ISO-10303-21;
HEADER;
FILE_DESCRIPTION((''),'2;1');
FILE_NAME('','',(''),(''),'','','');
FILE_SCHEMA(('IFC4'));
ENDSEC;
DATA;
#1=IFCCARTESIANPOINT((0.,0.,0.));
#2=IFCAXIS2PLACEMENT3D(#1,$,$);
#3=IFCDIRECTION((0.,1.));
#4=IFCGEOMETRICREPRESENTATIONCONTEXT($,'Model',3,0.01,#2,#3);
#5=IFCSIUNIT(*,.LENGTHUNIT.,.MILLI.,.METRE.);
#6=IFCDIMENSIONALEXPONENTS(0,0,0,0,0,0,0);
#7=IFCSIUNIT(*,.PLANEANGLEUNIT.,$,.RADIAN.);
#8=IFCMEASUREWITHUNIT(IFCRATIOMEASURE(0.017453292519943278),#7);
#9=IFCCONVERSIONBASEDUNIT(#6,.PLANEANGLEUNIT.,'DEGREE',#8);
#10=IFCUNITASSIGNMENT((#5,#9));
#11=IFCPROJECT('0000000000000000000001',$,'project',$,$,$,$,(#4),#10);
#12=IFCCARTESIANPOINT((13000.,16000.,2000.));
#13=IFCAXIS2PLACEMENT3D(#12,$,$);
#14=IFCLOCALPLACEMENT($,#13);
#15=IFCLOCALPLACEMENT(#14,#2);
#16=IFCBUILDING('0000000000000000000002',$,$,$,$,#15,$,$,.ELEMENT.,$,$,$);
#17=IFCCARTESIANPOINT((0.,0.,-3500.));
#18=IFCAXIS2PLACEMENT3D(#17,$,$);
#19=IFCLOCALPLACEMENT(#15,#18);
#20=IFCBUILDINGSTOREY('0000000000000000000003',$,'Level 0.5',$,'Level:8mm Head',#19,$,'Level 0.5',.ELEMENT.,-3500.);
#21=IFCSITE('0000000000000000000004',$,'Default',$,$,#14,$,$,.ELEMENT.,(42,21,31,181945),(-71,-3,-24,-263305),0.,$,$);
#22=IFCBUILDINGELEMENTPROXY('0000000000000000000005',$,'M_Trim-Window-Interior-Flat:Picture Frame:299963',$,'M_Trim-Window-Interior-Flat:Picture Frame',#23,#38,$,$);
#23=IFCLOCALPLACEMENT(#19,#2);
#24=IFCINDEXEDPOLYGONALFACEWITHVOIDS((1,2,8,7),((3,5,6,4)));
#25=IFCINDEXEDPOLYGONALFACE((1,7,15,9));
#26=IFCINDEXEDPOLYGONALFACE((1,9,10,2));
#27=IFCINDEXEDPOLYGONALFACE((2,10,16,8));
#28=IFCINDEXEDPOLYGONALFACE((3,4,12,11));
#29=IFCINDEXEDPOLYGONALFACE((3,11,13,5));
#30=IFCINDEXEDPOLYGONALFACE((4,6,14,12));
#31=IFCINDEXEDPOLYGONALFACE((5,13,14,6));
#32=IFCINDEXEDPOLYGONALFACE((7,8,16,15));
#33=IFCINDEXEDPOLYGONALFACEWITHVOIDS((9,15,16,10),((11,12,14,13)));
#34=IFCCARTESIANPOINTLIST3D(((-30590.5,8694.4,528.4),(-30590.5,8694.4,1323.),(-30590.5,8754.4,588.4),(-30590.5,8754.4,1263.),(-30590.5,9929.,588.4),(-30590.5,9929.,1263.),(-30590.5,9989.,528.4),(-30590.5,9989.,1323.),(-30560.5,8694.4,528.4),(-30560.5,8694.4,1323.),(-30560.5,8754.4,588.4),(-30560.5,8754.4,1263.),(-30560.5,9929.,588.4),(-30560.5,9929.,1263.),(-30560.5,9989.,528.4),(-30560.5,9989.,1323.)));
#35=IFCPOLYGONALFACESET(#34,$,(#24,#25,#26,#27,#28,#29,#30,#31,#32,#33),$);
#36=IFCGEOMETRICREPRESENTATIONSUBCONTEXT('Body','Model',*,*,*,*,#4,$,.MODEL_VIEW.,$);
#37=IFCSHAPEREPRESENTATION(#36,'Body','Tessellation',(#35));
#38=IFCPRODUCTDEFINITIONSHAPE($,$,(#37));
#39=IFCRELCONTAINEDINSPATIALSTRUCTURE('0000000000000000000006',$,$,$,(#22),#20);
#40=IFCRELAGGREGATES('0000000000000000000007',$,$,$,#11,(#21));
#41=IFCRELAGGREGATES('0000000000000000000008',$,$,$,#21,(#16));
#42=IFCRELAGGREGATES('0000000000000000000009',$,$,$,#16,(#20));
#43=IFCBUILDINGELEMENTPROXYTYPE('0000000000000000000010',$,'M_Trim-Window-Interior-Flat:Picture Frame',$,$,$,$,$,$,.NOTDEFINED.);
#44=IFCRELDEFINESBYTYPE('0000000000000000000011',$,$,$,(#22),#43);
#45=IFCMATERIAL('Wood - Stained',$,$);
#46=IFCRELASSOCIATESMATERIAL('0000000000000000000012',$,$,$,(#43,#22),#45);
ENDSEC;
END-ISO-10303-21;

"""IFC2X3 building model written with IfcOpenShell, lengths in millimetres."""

from ifc_helpers import new_model, entity, si_unit, converted_unit, direction, frame, origin, place, context, subcontext, project, spatial, polyline, outline, extrude, source, transform, mapped, material, type_object, type_shapes, element, save


model = new_model("IFC2X3")

# Units and contexts
model_context = context("Model", 3, precision=0.01, world=origin(), true_north=direction((0.0, 1.0)))
body_context = subcontext(model_context, "Body", "Model", "MODEL_VIEW")
ifc_project = project(units=[si_unit("LENGTHUNIT", "METRE", prefix="MILLI"), converted_unit("PLANEANGLEUNIT", "DEGREE", entity("IfcRatioMeasure", 0.017453292519943278), si_unit("PLANEANGLEUNIT", "RADIAN"), dimensions=[0, 0, 0, 0, 0, 0, 0])], contexts=[model_context])

# Site, building, storey
site_placement = place(None, frame((13000.0, 16000.0, 2000.0)))
site = spatial("IfcSite", under=ifc_project, at=site_placement, Name="Default", CompositionType="ELEMENT", RefLatitude=(42, 21, 31, 181945), RefLongitude=(-71, -3, -24, -263305), RefElevation=0.0)
building_placement = place(site_placement, origin())
building = spatial("IfcBuilding", under=site, at=building_placement, CompositionType="ELEMENT")
storey_placement = place(building_placement, frame((0.0, 0.0, -3500.0)))
storey = spatial("IfcBuildingStorey", under=building, at=storey_placement, Name="Level 0.5", ObjectType="Level:8mm Head", LongName="Level 0.5", CompositionType="ELEMENT", Elevation=-3500.0)

# Building element proxy
ifc_material_1 = material(Name="Wood - Stained")
building_element_proxy_type_1 = type_object("IfcBuildingElementProxyType", Name="M_Trim-Window-Interior-Flat:Picture Frame", PredefinedType="NOTDEFINED", material=ifc_material_1)
shared_shape_1 = source(origin(), body_context, "Body", "SweptSolid", [
    extrude(outline(polyline([(-647.3, -397.3), (647.3, -397.3), (647.3, 397.3), (-647.3, 397.3), (-647.3, -397.3)]), holes=[polyline([(-587.3, -337.3), (-587.3, 337.3), (587.3, 337.3), (587.3, -337.3), (-587.3, -337.3)])]), frame((0.0, -350.0, 0.0), z_axis=(0.0, 0.0, 1.0), x_axis=(-1.0, 0.0, 0.0)), (0.0, 0.0, 1.0), 30.0),
])
type_shapes(building_element_proxy_type_1, [shared_shape_1])
proxy_1_placement = place(storey_placement, frame((-30560.5, 9341.7, 1275.7), z_axis=(-1.0, 0.0, 0.0), x_axis=(0.0, -1.0, 0.0)))
element("IfcBuildingElementProxy", 1, at=proxy_1_placement, inside=storey, type_object=building_element_proxy_type_1, material=ifc_material_1, Name="M_Trim-Window-Interior-Flat:Picture Frame:299963", ObjectType="M_Trim-Window-Interior-Flat:Picture Frame", context=body_context, shape_type="MappedRepresentation", body=[
    mapped(shared_shape_1, transform((0.0, 0.0, 0.0), scale=1.0)),
])

save(model, "model.ifc")
